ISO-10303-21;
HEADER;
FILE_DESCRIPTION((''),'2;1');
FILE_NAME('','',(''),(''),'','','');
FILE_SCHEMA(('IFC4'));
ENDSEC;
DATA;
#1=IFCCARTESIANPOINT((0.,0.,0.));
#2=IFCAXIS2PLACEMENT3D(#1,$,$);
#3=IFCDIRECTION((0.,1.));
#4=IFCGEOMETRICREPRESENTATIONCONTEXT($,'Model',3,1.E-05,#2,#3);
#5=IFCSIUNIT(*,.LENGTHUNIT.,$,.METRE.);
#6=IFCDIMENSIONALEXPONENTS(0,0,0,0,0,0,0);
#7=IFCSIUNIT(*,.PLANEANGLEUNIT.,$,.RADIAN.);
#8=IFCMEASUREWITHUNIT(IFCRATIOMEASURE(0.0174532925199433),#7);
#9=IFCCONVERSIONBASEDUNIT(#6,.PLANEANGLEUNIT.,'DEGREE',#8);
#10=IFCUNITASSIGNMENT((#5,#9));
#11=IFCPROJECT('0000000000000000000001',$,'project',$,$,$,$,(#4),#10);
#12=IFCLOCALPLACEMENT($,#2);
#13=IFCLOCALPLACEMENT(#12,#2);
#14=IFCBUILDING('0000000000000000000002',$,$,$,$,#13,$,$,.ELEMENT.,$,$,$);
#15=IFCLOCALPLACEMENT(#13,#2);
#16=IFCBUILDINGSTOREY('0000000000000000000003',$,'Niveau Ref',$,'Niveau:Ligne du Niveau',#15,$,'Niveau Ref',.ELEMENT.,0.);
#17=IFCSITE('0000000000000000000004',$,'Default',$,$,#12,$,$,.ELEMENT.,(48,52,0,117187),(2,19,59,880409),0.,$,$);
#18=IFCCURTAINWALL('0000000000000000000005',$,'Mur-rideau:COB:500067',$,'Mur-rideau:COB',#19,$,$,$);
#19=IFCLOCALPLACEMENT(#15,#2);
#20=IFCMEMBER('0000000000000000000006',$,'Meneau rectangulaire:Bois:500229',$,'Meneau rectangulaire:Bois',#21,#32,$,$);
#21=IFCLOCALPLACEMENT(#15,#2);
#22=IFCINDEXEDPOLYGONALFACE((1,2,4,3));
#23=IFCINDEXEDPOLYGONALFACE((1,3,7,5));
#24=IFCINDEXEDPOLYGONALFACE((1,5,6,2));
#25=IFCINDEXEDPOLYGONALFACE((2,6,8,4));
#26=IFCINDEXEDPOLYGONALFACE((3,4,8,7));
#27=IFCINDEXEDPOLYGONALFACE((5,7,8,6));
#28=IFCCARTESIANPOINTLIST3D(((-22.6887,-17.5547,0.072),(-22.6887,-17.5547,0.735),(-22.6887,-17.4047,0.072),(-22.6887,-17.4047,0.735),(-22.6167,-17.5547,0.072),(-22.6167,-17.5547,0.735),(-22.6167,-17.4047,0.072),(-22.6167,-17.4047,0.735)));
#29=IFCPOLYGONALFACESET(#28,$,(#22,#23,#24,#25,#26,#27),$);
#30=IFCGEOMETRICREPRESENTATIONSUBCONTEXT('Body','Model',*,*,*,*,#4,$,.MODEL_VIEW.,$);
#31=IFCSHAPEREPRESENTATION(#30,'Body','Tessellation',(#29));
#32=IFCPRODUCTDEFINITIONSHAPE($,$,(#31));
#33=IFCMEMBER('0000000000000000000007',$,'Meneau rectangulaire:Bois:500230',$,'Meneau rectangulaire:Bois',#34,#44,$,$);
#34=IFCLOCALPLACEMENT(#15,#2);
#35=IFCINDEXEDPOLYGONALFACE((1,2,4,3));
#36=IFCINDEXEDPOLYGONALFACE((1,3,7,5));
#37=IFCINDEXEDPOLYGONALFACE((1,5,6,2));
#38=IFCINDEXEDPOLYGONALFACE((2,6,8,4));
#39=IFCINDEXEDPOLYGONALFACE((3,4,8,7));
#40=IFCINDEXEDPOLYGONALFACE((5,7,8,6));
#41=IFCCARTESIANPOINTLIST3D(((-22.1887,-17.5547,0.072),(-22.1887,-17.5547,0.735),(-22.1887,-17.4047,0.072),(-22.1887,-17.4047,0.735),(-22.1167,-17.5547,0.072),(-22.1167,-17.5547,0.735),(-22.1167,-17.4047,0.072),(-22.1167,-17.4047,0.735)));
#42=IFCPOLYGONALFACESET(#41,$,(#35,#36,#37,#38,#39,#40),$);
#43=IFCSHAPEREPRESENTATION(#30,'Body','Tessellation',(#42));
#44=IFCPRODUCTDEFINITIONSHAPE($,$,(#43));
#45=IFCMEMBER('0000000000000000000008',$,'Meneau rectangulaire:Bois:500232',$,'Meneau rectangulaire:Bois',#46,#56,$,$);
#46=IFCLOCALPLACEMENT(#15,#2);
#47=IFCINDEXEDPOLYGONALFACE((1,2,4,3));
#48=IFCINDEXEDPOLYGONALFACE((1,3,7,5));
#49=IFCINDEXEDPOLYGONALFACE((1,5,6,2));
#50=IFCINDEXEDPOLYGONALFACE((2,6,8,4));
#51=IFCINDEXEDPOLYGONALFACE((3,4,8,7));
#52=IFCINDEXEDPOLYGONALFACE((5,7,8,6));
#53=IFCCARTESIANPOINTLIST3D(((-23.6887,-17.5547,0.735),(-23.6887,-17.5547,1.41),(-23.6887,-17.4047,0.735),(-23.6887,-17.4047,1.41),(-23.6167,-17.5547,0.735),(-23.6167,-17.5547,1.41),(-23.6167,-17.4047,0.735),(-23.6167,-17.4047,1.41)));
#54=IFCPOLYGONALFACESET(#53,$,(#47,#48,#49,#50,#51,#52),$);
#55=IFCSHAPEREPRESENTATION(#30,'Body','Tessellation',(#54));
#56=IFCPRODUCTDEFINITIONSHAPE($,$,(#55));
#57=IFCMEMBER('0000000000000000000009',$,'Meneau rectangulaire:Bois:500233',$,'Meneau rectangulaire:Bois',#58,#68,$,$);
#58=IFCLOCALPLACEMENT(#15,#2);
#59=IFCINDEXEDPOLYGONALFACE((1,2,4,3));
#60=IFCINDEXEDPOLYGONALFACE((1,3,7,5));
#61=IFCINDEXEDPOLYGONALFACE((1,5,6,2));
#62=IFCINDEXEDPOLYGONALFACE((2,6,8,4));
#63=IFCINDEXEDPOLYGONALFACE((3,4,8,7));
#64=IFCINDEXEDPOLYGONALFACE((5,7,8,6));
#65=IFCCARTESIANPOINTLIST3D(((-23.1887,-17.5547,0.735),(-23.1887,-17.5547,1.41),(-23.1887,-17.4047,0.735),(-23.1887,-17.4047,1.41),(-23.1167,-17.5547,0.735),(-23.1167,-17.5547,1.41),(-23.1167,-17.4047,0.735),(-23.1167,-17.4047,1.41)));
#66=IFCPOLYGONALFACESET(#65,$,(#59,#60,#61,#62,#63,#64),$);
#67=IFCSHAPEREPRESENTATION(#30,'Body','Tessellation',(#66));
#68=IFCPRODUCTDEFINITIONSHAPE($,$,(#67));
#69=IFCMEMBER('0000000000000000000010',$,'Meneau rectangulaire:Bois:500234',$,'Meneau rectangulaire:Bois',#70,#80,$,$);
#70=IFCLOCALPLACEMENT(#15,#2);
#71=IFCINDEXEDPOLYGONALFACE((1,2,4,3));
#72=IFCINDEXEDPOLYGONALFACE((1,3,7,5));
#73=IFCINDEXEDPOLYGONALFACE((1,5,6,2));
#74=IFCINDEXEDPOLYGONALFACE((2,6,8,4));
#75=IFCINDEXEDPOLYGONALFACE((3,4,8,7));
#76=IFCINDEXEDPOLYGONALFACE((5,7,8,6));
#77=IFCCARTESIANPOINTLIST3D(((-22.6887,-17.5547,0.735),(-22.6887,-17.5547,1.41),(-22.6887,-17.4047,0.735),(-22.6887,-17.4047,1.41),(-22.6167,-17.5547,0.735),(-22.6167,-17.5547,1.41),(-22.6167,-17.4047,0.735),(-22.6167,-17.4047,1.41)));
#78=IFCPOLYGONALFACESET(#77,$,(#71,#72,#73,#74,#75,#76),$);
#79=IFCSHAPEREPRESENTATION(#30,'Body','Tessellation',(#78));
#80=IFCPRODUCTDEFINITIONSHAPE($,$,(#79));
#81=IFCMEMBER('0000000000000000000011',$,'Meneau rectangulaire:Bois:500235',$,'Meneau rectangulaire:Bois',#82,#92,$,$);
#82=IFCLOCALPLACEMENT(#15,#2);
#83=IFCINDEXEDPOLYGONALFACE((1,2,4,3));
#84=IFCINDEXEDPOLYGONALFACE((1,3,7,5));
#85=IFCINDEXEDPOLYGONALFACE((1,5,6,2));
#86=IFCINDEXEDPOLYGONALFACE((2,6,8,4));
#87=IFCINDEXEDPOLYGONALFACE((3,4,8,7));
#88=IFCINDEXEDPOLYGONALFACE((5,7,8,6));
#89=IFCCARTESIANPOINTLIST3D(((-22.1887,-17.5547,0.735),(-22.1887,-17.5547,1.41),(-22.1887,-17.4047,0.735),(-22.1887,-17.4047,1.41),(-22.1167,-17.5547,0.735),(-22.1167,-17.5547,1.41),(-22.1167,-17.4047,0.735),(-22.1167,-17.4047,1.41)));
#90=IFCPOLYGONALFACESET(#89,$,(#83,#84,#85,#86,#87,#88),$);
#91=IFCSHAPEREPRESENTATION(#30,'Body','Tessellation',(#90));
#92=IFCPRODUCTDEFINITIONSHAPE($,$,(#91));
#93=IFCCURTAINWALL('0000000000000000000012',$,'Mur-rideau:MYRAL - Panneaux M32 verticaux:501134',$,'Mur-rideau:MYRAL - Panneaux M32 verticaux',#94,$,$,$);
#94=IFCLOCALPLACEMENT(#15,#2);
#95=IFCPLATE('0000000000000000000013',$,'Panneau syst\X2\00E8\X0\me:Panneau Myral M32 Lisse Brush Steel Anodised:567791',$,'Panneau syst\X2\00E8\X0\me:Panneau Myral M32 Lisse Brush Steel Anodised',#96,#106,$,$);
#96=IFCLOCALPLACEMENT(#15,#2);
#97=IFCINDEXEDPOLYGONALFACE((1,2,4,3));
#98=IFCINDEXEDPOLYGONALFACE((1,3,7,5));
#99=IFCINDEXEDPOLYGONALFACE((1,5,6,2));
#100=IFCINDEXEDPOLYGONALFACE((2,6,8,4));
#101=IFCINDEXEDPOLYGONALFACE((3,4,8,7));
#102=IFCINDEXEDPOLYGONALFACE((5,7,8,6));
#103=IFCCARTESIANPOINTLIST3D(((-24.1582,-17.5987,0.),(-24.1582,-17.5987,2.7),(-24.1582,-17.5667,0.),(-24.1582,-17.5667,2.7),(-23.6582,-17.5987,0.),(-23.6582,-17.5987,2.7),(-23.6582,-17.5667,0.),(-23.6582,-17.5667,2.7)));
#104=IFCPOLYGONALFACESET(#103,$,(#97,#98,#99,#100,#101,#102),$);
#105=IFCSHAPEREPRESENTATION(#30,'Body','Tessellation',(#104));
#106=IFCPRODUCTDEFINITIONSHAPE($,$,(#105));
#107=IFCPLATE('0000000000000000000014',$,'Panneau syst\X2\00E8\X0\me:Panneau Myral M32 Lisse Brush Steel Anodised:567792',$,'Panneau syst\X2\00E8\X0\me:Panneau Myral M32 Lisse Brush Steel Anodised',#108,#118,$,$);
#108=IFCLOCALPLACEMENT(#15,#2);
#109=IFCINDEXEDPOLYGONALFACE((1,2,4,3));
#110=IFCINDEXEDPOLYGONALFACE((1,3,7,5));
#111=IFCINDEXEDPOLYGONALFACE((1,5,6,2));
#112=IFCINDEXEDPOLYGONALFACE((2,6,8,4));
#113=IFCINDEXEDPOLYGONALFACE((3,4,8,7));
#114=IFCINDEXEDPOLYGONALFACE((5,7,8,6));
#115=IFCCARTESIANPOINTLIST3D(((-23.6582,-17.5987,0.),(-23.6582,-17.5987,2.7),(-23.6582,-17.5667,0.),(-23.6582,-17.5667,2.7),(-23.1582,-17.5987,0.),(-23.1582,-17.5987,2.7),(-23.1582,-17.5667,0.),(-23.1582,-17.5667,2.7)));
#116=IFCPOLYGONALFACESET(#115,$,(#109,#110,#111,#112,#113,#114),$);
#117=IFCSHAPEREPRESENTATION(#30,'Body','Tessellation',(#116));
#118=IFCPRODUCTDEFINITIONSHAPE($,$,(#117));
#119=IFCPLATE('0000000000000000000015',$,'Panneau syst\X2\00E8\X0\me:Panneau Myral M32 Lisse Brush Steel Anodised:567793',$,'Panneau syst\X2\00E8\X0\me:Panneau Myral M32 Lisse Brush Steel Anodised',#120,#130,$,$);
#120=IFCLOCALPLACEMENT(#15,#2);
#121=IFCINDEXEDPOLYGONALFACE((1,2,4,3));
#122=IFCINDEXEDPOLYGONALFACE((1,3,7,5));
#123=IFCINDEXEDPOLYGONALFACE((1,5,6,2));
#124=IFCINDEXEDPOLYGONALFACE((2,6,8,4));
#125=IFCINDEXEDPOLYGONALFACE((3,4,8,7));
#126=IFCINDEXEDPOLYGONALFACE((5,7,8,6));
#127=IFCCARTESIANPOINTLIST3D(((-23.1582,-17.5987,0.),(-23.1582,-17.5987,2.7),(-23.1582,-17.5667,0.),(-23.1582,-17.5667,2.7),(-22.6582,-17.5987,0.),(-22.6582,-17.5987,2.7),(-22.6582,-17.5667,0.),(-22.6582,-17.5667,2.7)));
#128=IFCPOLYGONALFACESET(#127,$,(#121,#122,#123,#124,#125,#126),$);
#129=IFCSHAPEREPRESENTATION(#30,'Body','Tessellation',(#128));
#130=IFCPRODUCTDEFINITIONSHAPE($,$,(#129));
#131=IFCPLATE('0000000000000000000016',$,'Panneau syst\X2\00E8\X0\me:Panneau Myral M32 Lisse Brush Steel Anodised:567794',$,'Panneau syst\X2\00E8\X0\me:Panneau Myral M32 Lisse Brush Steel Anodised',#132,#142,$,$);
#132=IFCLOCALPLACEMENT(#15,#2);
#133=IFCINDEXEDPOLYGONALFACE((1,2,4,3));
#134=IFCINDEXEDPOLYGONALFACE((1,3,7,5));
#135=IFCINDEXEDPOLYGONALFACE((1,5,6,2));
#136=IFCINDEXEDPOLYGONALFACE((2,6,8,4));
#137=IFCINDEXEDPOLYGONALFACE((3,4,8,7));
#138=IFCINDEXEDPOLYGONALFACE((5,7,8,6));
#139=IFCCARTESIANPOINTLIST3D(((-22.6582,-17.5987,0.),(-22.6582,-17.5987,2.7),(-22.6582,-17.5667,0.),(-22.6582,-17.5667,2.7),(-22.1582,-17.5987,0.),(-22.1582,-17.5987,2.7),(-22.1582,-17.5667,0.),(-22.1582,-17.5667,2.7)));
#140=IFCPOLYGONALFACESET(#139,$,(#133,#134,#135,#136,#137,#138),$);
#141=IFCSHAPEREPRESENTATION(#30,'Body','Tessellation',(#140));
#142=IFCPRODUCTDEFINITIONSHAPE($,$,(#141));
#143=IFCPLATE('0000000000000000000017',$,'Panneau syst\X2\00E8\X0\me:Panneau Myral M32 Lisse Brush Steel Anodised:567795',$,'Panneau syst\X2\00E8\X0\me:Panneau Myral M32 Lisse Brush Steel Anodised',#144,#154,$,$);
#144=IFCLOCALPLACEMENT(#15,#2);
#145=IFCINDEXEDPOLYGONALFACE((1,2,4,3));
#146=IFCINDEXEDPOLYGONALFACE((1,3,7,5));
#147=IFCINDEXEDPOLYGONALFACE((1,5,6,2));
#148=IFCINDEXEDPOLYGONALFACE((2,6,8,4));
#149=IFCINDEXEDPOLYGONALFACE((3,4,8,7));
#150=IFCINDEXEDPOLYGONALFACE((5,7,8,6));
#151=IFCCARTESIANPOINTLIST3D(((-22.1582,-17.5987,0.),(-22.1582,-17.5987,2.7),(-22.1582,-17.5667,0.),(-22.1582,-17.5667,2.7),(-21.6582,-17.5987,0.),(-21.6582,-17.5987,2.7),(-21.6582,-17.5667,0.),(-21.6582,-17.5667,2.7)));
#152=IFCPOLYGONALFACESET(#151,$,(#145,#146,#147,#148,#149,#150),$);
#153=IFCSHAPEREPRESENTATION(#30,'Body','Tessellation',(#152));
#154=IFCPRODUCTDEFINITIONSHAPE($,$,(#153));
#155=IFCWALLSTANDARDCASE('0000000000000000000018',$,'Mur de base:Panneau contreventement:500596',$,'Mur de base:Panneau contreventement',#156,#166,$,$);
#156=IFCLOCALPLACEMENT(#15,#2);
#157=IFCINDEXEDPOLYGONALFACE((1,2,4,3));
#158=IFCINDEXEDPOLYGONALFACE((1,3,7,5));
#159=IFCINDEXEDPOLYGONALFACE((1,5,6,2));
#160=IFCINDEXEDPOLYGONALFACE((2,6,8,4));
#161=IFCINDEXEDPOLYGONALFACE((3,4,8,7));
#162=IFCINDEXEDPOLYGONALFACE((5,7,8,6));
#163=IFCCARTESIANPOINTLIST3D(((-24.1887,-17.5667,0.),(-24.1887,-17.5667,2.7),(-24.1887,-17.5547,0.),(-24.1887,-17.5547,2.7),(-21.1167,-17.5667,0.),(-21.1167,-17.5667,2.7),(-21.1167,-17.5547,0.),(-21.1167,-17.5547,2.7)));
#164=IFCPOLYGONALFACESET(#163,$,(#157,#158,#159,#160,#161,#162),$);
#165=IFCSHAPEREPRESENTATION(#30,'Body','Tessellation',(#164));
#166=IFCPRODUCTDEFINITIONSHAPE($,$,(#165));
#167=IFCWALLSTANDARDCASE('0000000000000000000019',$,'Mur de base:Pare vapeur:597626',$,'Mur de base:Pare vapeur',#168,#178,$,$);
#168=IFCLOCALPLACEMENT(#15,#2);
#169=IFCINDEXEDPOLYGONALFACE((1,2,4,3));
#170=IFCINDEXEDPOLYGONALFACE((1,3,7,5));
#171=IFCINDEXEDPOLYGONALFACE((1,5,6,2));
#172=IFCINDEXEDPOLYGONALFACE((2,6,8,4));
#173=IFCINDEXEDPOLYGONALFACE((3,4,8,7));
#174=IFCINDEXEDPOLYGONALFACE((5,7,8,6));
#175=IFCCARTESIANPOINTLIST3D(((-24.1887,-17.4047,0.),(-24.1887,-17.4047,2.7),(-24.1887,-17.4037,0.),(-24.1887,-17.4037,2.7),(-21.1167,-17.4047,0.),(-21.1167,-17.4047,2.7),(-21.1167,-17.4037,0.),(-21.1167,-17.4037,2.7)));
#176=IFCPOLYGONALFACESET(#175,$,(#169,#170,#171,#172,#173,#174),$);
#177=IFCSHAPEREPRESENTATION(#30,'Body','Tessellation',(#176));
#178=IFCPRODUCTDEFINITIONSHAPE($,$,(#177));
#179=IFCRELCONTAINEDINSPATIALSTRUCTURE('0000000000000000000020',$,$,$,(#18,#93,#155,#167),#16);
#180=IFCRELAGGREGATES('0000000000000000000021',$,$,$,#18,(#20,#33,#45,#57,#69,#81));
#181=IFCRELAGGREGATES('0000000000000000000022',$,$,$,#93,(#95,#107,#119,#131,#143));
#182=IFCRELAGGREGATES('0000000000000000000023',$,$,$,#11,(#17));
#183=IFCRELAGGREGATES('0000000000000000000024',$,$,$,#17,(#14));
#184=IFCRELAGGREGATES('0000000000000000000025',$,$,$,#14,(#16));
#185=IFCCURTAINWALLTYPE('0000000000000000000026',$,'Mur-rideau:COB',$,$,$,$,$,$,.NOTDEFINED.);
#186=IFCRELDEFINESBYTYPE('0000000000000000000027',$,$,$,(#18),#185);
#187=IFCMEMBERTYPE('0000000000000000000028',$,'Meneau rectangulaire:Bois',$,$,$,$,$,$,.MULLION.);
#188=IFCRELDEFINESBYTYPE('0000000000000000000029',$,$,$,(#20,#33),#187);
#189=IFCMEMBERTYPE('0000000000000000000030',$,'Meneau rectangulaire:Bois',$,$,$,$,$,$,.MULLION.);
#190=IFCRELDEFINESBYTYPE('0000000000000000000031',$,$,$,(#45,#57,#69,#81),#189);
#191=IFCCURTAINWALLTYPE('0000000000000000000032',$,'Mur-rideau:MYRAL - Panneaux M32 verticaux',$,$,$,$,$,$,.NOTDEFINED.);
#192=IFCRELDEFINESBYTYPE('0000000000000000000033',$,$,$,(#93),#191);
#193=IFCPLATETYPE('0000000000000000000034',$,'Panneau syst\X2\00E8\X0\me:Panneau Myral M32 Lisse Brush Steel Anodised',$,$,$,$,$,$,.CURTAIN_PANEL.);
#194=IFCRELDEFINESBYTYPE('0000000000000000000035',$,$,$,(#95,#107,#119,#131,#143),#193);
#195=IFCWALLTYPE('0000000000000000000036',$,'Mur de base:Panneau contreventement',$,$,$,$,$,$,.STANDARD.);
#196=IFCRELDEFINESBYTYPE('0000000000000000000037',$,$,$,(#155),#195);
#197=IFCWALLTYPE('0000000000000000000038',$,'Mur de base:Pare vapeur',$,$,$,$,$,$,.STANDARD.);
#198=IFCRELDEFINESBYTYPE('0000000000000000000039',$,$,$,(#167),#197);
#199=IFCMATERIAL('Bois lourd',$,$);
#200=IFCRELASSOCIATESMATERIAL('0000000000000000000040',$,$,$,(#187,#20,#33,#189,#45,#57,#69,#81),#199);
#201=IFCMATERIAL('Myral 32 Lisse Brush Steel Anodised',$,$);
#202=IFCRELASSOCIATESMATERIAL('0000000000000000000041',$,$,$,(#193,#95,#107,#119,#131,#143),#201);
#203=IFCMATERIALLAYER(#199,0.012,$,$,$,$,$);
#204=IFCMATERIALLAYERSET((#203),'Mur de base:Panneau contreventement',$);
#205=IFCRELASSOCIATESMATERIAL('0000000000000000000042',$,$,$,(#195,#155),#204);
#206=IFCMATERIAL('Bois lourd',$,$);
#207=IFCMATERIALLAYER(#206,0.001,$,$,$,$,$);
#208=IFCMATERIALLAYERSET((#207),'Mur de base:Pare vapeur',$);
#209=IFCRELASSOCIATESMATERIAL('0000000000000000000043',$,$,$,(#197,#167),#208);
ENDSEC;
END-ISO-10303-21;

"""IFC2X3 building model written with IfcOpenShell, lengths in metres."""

from ifc_helpers import new_model, entity, si_unit, converted_unit, direction, frame, frame_2d, origin, origin_2d_with_axis, place, context, subcontext, project, spatial, rectangle, extrude, source, transform, mapped, material, layer, layer_set, layer_usage, type_object, type_shapes, element, aggregate, save


model = new_model("IFC2X3")

# Units and contexts
model_context = context("Model", 3, precision=1e-05, world=origin(), true_north=direction((0.0, 1.0)))
body_context = subcontext(model_context, "Body", "Model", "MODEL_VIEW")
ifc_project = project(units=[si_unit("LENGTHUNIT", "METRE"), converted_unit("PLANEANGLEUNIT", "DEGREE", entity("IfcRatioMeasure", 0.0174532925199433), si_unit("PLANEANGLEUNIT", "RADIAN"), dimensions=[0, 0, 0, 0, 0, 0, 0])], contexts=[model_context])

# Site, building, storey
site_placement = place(None, origin())
site = spatial("IfcSite", under=ifc_project, at=site_placement, Name="Default", CompositionType="ELEMENT", RefLatitude=(48, 52, 0, 117187), RefLongitude=(2, 19, 59, 880409), RefElevation=0.0)
building_placement = place(site_placement, origin())
building = spatial("IfcBuilding", under=site, at=building_placement, CompositionType="ELEMENT")
storey_placement = place(building_placement, origin())
storey = spatial("IfcBuildingStorey", under=building, at=storey_placement, Name="Niveau Ref", ObjectType="Niveau:Ligne du Niveau", LongName="Niveau Ref", CompositionType="ELEMENT", Elevation=0.0)

# Curtain wall, members
curtain_wall_type_1 = type_object("IfcCurtainWallType", Name="Mur-rideau:COB", PredefinedType="NOTDEFINED")
curtain_wall_1_placement = place(storey_placement, origin())
curtain_wall_1 = element("IfcCurtainWall", 1, at=curtain_wall_1_placement, inside=storey, type_object=curtain_wall_type_1, Name="Mur-rideau:COB:500067", ObjectType="Mur-rideau:COB")
ifc_material_1 = material(Name="Bois lourd")
member_type_1 = type_object("IfcMemberType", Name="Meneau rectangulaire:Bois", PredefinedType="MULLION", material=ifc_material_1)
shared_shape_1 = source(origin(), body_context, "Body", "SweptSolid", [
    extrude(rectangle(XDim=0.15, YDim=0.072, at=origin_2d_with_axis()), frame((-0.024, 0.0, -0.663), z_axis=(0.0, 0.0, 1.0), x_axis=(0.0, -1.0, 0.0)), (0.0, 0.0, 1.0), 0.663),
])
type_shapes(member_type_1, [shared_shape_1])
member_1_placement = place(storey_placement, frame((-22.6287, -17.4797, 0.072), z_axis=(0.0, 0.0, -1.0), x_axis=(1.0, 0.0, 0.0)))
member_1 = element("IfcMember", 2, at=member_1_placement, type_object=member_type_1, material=ifc_material_1, Name="Meneau rectangulaire:Bois:500229", ObjectType="Meneau rectangulaire:Bois", context=body_context, shape_type="MappedRepresentation", body=[
    mapped(shared_shape_1, transform((0.0, 0.0, 0.0), scale=1.0)),
])
member_2_placement = place(storey_placement, frame((-22.1287, -17.4797, 0.072), z_axis=(0.0, 0.0, -1.0), x_axis=(1.0, 0.0, 0.0)))
member_2 = element("IfcMember", 3, at=member_2_placement, type_object=member_type_1, material=ifc_material_1, Name="Meneau rectangulaire:Bois:500230", ObjectType="Meneau rectangulaire:Bois", context=body_context, shape_type="MappedRepresentation", body=[
    mapped(shared_shape_1, transform((0.0, 0.0, 0.0), scale=1.0)),
])
member_type_2 = type_object("IfcMemberType", Name="Meneau rectangulaire:Bois", PredefinedType="MULLION", material=ifc_material_1)
shared_shape_2 = source(origin(), body_context, "Body", "SweptSolid", [
    extrude(rectangle(XDim=0.15, YDim=0.072, at=origin_2d_with_axis()), frame((-0.024, 0.0, -0.675), z_axis=(0.0, 0.0, 1.0), x_axis=(0.0, -1.0, 0.0)), (0.0, 0.0, 1.0), 0.675),
])
type_shapes(member_type_2, [shared_shape_2])
member_3_placement = place(storey_placement, frame((-23.6287, -17.4797, 0.735), z_axis=(0.0, 0.0, -1.0), x_axis=(1.0, 0.0, 0.0)))
member_3 = element("IfcMember", 4, at=member_3_placement, type_object=member_type_2, material=ifc_material_1, Name="Meneau rectangulaire:Bois:500232", ObjectType="Meneau rectangulaire:Bois", context=body_context, shape_type="MappedRepresentation", body=[
    mapped(shared_shape_2, transform((0.0, 0.0, 0.0), scale=1.0)),
])
member_4_placement = place(storey_placement, frame((-23.1287, -17.4797, 0.735), z_axis=(0.0, 0.0, -1.0), x_axis=(1.0, 0.0, 0.0)))
member_4 = element("IfcMember", 5, at=member_4_placement, type_object=member_type_2, material=ifc_material_1, Name="Meneau rectangulaire:Bois:500233", ObjectType="Meneau rectangulaire:Bois", context=body_context, shape_type="MappedRepresentation", body=[
    mapped(shared_shape_2, transform((0.0, 0.0, 0.0), scale=1.0)),
])
member_5_placement = place(storey_placement, frame((-22.6287, -17.4797, 0.735), z_axis=(0.0, 0.0, -1.0), x_axis=(1.0, 0.0, 0.0)))
member_5 = element("IfcMember", 6, at=member_5_placement, type_object=member_type_2, material=ifc_material_1, Name="Meneau rectangulaire:Bois:500234", ObjectType="Meneau rectangulaire:Bois", context=body_context, shape_type="MappedRepresentation", body=[
    mapped(shared_shape_2, transform((0.0, 0.0, 0.0), scale=1.0)),
])
member_6_placement = place(storey_placement, frame((-22.1287, -17.4797, 0.735), z_axis=(0.0, 0.0, -1.0), x_axis=(1.0, 0.0, 0.0)))
member_6 = element("IfcMember", 7, at=member_6_placement, type_object=member_type_2, material=ifc_material_1, Name="Meneau rectangulaire:Bois:500235", ObjectType="Meneau rectangulaire:Bois", context=body_context, shape_type="MappedRepresentation", body=[
    mapped(shared_shape_2, transform((0.0, 0.0, 0.0), scale=1.0)),
])
aggregate(curtain_wall_1, [member_1, member_2, member_3, member_4, member_5, member_6])

# Curtain wall, plates
curtain_wall_type_2 = type_object("IfcCurtainWallType", Name="Mur-rideau:MYRAL - Panneaux M32 verticaux", PredefinedType="NOTDEFINED")
curtain_wall_2_placement = place(storey_placement, origin())
curtain_wall_2 = element("IfcCurtainWall", 8, at=curtain_wall_2_placement, inside=storey, type_object=curtain_wall_type_2, Name="Mur-rideau:MYRAL - Panneaux M32 verticaux:501134", ObjectType="Mur-rideau:MYRAL - Panneaux M32 verticaux")
ifc_material_2 = material(Name="Myral 32 Lisse Brush Steel Anodised")
plate_type = type_object("IfcPlateType", Name="Panneau système:Panneau Myral M32 Lisse Brush Steel Anodised", PredefinedType="CURTAIN_PANEL", material=ifc_material_2)
shared_shape_3 = source(origin(), body_context, "Body", "SweptSolid", [
    extrude(rectangle(XDim=0.032, YDim=0.5, at=origin_2d_with_axis()), frame((0.0, -0.016, 0.0), z_axis=(0.0, 0.0, 1.0), x_axis=(0.0, 1.0, 0.0)), (0.0, 0.0, 1.0), 2.7),
])
type_shapes(plate_type, [shared_shape_3])
plate_1_placement = place(curtain_wall_2_placement, frame((-23.9082, -17.5667, 0.0)))
plate_1 = element("IfcPlate", 9, at=plate_1_placement, type_object=plate_type, material=ifc_material_2, Name="Panneau système:Panneau Myral M32 Lisse Brush Steel Anodised:567791", ObjectType="Panneau système:Panneau Myral M32 Lisse Brush Steel Anodised", context=body_context, shape_type="MappedRepresentation", body=[
    mapped(shared_shape_3, transform((0.0, 0.0, 0.0), scale=1.0)),
])
plate_2_placement = place(curtain_wall_2_placement, frame((-23.4082, -17.5667, 0.0)))
plate_2 = element("IfcPlate", 10, at=plate_2_placement, type_object=plate_type, material=ifc_material_2, Name="Panneau système:Panneau Myral M32 Lisse Brush Steel Anodised:567792", ObjectType="Panneau système:Panneau Myral M32 Lisse Brush Steel Anodised", context=body_context, shape_type="MappedRepresentation", body=[
    mapped(shared_shape_3, transform((0.0, 0.0, 0.0), scale=1.0)),
])
plate_3_placement = place(curtain_wall_2_placement, frame((-22.9082, -17.5667, 0.0)))
plate_3 = element("IfcPlate", 11, at=plate_3_placement, type_object=plate_type, material=ifc_material_2, Name="Panneau système:Panneau Myral M32 Lisse Brush Steel Anodised:567793", ObjectType="Panneau système:Panneau Myral M32 Lisse Brush Steel Anodised", context=body_context, shape_type="MappedRepresentation", body=[
    mapped(shared_shape_3, transform((0.0, 0.0, 0.0), scale=1.0)),
])
plate_4_placement = place(curtain_wall_2_placement, frame((-22.4082, -17.5667, 0.0)))
plate_4 = element("IfcPlate", 12, at=plate_4_placement, type_object=plate_type, material=ifc_material_2, Name="Panneau système:Panneau Myral M32 Lisse Brush Steel Anodised:567794", ObjectType="Panneau système:Panneau Myral M32 Lisse Brush Steel Anodised", context=body_context, shape_type="MappedRepresentation", body=[
    mapped(shared_shape_3, transform((0.0, 0.0, 0.0), scale=1.0)),
])
plate_5_placement = place(curtain_wall_2_placement, frame((-21.9082, -17.5667, 0.0)))
plate_5 = element("IfcPlate", 13, at=plate_5_placement, type_object=plate_type, material=ifc_material_2, Name="Panneau système:Panneau Myral M32 Lisse Brush Steel Anodised:567795", ObjectType="Panneau système:Panneau Myral M32 Lisse Brush Steel Anodised", context=body_context, shape_type="MappedRepresentation", body=[
    mapped(shared_shape_3, transform((0.0, 0.0, 0.0), scale=1.0)),
])
aggregate(curtain_wall_2, [plate_1, plate_2, plate_3, plate_4, plate_5])

# Walls
ifc_layer_1 = layer(ifc_material_1, 0.012)
ifc_layer_set_1 = layer_set([ifc_layer_1], Name="Mur de base:Panneau contreventement")
ifc_layer_usage_1 = layer_usage(ifc_layer_set_1, "AXIS2", "NEGATIVE", 0.006)
wall_type_1 = type_object("IfcWallType", Name="Mur de base:Panneau contreventement", PredefinedType="STANDARD", material=ifc_layer_set_1)
wall_1_placement = place(storey_placement, frame((-24.1887, -17.5607, 0.0)))
element("IfcWallStandardCase", 14, at=wall_1_placement, inside=storey, type_object=wall_type_1, material=ifc_layer_usage_1, Name="Mur de base:Panneau contreventement:500596", ObjectType="Mur de base:Panneau contreventement", context=body_context, shape_type="SweptSolid", body=[
    extrude(rectangle(XDim=3.072, YDim=0.012, at=frame_2d((1.536, 0.0), x_axis=(-1.0, 0.0))), origin(), (0.0, 0.0, 1.0), 2.7),
])
ifc_material_3 = material(Name="Bois lourd")
ifc_layer_2 = layer(ifc_material_3, 0.001)
ifc_layer_set_2 = layer_set([ifc_layer_2], Name="Mur de base:Pare vapeur")
ifc_layer_usage_2 = layer_usage(ifc_layer_set_2, "AXIS2", "NEGATIVE", 0.0005)
wall_type_2 = type_object("IfcWallType", Name="Mur de base:Pare vapeur", PredefinedType="STANDARD", material=ifc_layer_set_2)
wall_2_placement = place(storey_placement, frame((-24.1887, -17.4042, 0.0)))
element("IfcWallStandardCase", 15, at=wall_2_placement, inside=storey, type_object=wall_type_2, material=ifc_layer_usage_2, Name="Mur de base:Pare vapeur:597626", ObjectType="Mur de base:Pare vapeur", context=body_context, shape_type="SweptSolid", body=[
    extrude(rectangle(XDim=3.072, YDim=0.001, at=frame_2d((1.536, 0.0), x_axis=(-1.0, 0.0))), origin(), (0.0, 0.0, 1.0), 2.7),
])

save(model, "model.ifc")
